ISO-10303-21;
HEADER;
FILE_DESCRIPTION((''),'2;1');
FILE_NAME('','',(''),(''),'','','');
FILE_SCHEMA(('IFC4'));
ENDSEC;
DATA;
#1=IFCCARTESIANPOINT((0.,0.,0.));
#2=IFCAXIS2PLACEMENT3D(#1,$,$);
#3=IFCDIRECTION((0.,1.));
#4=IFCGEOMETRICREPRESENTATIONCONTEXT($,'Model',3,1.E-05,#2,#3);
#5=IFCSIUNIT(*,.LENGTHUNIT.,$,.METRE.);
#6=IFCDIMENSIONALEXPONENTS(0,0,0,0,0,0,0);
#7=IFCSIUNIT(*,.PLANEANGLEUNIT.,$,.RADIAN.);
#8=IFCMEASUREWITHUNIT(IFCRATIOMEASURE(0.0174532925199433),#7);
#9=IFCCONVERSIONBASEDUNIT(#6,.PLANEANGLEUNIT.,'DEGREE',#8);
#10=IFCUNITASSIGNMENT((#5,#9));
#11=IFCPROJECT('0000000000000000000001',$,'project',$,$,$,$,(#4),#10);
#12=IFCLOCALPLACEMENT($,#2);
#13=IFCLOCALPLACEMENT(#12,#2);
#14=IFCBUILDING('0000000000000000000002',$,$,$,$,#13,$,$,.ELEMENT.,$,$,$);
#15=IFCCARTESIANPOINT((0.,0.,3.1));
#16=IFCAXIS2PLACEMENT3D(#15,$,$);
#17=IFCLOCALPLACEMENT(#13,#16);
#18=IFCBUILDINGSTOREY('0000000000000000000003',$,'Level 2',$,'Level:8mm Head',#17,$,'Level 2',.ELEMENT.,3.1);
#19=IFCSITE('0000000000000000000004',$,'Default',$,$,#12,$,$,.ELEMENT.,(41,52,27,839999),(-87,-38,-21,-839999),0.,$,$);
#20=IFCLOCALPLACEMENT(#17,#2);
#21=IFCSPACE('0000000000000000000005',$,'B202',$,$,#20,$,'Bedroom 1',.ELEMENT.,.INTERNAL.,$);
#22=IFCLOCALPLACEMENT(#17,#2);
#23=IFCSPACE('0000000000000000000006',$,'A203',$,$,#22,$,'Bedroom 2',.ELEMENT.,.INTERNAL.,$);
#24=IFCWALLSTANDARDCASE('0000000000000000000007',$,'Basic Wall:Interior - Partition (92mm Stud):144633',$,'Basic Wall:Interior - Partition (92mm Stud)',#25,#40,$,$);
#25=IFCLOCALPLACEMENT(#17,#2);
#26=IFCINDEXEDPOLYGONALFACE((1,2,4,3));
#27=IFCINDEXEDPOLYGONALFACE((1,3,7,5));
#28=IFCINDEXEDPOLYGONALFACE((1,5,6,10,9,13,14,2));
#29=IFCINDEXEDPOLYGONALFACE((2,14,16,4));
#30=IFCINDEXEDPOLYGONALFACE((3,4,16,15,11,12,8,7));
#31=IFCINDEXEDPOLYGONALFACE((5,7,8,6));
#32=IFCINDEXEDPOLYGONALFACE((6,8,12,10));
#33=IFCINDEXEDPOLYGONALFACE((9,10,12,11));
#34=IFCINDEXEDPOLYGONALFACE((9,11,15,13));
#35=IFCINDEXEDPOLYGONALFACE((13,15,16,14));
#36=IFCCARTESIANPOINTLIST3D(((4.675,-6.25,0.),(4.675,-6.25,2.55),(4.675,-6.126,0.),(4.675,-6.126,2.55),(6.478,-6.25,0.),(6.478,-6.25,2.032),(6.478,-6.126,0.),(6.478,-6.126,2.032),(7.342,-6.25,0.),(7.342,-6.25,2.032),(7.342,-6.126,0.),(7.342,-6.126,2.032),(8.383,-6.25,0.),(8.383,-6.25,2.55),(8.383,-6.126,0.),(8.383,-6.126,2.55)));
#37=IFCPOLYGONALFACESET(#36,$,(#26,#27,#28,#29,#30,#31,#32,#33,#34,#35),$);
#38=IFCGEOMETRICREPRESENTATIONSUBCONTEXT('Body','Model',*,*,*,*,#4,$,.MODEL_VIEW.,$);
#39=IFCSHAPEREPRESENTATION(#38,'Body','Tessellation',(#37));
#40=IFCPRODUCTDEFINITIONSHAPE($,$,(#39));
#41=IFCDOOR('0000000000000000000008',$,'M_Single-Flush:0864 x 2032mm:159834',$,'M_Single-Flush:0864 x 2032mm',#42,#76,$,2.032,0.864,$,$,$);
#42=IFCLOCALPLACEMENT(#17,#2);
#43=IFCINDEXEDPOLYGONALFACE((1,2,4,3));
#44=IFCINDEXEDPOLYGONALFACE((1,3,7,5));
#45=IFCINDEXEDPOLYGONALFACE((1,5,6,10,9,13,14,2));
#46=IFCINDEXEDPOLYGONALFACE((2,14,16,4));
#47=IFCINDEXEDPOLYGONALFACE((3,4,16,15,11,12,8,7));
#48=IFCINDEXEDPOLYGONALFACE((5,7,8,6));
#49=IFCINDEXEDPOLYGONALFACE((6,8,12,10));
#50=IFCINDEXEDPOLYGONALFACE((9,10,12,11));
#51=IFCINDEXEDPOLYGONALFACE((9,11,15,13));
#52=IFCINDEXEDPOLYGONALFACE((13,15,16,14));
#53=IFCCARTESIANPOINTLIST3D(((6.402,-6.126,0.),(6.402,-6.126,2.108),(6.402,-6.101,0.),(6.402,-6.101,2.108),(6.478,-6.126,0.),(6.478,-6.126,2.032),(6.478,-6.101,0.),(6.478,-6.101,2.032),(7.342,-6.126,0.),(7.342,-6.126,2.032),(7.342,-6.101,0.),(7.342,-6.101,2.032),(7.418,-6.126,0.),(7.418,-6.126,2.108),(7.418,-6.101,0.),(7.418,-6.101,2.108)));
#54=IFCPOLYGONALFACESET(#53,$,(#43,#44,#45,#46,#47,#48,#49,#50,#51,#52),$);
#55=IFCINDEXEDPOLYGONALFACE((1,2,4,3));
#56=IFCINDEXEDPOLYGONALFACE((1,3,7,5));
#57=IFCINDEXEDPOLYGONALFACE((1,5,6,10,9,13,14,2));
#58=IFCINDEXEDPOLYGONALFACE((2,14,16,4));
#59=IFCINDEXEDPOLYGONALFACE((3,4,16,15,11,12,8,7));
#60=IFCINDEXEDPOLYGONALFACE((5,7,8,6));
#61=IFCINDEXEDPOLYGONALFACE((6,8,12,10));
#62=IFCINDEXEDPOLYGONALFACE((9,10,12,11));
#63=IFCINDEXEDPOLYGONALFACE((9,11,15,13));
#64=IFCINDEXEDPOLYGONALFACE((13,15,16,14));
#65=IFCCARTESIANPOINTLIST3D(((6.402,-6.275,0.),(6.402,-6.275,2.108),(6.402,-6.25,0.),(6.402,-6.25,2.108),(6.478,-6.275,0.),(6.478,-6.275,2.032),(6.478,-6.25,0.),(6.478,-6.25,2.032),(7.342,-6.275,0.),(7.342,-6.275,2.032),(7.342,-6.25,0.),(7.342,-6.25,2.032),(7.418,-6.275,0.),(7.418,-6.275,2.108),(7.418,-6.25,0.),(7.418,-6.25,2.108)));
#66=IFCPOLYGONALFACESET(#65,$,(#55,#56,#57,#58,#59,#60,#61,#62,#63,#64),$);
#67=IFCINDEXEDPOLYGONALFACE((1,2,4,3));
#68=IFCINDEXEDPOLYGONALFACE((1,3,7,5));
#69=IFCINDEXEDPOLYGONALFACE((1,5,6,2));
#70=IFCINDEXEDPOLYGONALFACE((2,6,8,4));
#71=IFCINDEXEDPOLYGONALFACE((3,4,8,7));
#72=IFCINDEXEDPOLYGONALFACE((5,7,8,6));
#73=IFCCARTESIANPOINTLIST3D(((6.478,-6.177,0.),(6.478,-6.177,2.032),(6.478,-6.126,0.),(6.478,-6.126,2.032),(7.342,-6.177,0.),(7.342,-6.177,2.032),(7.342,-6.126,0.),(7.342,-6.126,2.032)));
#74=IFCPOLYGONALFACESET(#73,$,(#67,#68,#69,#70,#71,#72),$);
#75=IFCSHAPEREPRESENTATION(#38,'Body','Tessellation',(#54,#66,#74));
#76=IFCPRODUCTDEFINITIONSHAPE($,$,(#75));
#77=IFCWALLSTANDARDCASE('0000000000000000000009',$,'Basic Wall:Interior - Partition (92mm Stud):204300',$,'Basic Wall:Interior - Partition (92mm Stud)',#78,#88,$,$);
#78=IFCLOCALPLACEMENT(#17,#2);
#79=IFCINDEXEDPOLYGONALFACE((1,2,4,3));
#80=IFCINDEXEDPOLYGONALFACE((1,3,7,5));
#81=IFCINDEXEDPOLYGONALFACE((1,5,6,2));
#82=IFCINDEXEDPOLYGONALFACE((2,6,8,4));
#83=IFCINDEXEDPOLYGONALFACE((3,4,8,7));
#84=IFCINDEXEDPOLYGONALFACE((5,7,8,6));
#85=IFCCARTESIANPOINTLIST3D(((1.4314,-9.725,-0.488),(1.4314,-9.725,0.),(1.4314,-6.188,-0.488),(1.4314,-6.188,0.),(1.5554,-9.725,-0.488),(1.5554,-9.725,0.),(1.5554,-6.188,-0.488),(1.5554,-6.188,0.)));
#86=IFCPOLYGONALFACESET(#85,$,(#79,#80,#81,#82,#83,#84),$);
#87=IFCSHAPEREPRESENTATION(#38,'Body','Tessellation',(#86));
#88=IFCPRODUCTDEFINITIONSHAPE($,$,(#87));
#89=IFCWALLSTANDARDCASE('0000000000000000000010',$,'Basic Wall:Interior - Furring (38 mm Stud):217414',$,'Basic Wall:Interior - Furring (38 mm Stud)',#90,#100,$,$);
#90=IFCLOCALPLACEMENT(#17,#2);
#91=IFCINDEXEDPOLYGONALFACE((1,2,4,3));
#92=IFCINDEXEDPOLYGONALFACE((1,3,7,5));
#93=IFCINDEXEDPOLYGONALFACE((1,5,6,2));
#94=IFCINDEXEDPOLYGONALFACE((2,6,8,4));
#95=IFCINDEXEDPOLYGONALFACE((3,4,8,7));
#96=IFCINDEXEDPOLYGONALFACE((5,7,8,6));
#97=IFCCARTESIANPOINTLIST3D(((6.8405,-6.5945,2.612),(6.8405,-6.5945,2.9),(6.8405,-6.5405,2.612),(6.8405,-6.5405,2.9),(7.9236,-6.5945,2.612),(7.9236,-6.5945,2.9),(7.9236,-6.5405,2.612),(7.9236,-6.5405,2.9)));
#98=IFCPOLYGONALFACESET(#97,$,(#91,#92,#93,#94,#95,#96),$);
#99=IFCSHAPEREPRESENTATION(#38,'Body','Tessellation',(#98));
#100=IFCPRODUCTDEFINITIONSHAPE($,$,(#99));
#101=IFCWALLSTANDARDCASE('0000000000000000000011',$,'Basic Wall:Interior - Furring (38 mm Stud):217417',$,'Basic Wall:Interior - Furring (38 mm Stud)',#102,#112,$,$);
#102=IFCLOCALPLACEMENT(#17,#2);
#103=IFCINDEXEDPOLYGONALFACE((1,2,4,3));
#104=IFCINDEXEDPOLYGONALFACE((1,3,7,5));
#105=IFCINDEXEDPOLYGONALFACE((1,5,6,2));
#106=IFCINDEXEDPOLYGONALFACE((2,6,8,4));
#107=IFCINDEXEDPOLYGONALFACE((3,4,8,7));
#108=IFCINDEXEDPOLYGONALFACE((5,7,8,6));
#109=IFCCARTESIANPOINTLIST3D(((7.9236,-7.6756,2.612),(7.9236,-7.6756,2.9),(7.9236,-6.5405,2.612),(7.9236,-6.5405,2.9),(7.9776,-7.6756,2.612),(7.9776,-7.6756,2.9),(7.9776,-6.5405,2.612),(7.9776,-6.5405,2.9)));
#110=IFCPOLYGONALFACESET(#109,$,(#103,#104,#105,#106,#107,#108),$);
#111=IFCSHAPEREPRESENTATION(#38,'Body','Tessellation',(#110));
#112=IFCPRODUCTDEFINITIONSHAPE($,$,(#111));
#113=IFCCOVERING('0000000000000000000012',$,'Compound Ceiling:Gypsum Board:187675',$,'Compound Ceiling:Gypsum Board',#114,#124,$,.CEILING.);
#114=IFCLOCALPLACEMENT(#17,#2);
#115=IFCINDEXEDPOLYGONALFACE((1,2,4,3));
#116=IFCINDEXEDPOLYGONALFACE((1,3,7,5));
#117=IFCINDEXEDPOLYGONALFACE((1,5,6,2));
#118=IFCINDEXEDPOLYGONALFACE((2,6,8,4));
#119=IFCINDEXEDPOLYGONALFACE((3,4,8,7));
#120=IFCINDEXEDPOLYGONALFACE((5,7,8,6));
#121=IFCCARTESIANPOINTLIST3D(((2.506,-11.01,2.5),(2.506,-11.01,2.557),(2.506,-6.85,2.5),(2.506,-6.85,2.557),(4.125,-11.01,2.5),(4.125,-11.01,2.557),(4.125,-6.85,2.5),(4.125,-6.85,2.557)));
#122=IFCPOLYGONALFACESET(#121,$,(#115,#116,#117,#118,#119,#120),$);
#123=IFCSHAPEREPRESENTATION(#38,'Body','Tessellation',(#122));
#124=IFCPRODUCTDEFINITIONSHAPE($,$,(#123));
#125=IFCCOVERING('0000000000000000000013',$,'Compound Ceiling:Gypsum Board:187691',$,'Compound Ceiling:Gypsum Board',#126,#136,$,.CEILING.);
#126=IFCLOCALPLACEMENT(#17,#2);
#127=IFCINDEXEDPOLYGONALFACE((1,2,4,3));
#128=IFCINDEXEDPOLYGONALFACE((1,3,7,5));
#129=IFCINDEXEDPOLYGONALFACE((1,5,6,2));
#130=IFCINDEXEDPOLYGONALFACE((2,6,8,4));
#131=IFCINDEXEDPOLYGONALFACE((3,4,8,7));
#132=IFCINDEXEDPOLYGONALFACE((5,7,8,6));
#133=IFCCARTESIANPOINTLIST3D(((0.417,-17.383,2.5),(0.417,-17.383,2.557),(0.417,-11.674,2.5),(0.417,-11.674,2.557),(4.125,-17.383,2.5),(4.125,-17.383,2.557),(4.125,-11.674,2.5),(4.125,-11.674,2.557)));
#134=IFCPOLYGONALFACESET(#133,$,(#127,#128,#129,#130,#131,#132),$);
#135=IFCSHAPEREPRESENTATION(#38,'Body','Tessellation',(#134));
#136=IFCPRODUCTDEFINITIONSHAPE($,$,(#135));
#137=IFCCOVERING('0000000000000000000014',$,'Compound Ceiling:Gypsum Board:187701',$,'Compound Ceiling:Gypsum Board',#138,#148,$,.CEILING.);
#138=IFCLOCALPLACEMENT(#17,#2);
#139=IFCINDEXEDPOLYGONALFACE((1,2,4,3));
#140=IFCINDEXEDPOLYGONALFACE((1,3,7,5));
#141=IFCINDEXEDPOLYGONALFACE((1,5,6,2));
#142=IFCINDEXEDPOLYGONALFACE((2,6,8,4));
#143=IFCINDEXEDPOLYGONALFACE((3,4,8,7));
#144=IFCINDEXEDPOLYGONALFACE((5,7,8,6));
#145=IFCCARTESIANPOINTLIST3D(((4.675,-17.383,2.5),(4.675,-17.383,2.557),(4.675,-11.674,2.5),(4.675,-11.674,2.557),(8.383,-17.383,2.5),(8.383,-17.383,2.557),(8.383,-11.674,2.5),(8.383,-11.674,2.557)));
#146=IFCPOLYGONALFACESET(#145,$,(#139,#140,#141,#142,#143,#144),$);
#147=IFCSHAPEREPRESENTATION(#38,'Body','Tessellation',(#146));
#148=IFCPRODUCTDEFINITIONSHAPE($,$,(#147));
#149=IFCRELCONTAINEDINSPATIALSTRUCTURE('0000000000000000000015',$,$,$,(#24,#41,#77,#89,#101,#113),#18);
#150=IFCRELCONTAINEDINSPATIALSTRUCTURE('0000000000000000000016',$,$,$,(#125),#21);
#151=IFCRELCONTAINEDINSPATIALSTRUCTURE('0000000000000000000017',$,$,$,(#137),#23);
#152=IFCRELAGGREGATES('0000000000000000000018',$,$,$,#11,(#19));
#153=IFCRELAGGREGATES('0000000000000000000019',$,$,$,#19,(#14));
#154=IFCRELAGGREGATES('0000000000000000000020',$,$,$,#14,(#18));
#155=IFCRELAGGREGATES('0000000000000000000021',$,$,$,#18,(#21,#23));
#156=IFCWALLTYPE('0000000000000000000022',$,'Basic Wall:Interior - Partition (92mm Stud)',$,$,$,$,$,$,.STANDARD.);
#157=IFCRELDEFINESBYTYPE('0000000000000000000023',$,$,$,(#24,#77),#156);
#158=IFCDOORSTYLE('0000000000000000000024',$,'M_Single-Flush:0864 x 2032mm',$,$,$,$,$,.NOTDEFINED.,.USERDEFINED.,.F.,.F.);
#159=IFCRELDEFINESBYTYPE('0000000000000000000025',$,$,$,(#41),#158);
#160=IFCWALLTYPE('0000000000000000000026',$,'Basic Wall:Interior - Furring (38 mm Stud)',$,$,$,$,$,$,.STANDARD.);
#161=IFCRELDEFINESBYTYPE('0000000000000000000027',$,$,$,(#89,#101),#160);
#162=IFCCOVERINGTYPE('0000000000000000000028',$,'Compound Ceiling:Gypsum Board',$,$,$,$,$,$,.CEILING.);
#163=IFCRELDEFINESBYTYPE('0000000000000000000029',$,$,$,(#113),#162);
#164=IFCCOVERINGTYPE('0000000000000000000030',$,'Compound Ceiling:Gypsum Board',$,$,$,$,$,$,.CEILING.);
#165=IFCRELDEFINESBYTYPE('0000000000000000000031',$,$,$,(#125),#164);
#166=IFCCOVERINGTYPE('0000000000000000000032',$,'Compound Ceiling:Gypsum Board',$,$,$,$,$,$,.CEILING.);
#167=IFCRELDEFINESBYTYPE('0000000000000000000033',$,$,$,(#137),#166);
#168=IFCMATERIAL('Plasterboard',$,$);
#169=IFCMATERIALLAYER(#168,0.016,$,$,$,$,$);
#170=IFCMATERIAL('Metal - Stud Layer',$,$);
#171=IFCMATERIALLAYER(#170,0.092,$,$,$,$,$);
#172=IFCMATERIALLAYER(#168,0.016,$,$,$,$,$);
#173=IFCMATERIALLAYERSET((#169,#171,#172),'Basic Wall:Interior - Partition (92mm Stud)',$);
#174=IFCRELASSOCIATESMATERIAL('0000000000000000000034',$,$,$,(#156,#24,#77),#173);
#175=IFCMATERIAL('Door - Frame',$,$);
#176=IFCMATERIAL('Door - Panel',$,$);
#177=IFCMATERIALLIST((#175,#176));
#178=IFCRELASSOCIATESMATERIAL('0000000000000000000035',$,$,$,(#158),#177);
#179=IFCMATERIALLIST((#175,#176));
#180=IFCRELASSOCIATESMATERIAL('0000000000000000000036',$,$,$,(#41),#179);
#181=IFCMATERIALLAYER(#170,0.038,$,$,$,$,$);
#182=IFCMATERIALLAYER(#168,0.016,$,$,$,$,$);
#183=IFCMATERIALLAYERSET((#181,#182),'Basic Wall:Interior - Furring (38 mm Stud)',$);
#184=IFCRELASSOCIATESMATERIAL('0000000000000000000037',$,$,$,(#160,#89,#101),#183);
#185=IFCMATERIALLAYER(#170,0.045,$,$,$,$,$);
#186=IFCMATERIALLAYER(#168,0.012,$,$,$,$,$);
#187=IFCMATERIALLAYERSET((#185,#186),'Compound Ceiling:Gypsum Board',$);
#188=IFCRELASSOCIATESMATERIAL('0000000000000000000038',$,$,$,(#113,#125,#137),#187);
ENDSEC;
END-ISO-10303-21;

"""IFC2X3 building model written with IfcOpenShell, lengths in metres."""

from ifc_helpers import new_model, entity, si_unit, converted_unit, direction, frame, frame_2d, origin, place, context, subcontext, project, spatial, polyline, rectangle, outline, extrude, source, transform, mapped, material, material_list, layer, layer_set, layer_usage, type_object, type_shapes, element, fill, save


model = new_model("IFC2X3")

# Units and contexts
model_context = context("Model", 3, precision=1e-05, world=origin(), true_north=direction((0.0, 1.0)))
body_context = subcontext(model_context, "Body", "Model", "MODEL_VIEW")
ifc_project = project(units=[si_unit("LENGTHUNIT", "METRE"), converted_unit("PLANEANGLEUNIT", "DEGREE", entity("IfcRatioMeasure", 0.0174532925199433), si_unit("PLANEANGLEUNIT", "RADIAN"), dimensions=[0, 0, 0, 0, 0, 0, 0])], contexts=[model_context])

# Site, building, storey
site_placement = place(None, origin())
site = spatial("IfcSite", under=ifc_project, at=site_placement, Name="Default", CompositionType="ELEMENT", RefLatitude=(41, 52, 27, 839999), RefLongitude=(-87, -38, -21, -839999), RefElevation=0.0)
building_placement = place(site_placement, origin())
building = spatial("IfcBuilding", under=site, at=building_placement, CompositionType="ELEMENT")
storey_placement = place(building_placement, frame((0.0, 0.0, 3.1)))
storey = spatial("IfcBuildingStorey", under=building, at=storey_placement, Name="Level 2", ObjectType="Level:8mm Head", LongName="Level 2", CompositionType="ELEMENT", Elevation=3.1)

# Shared definitions
ifc_material_1 = material(Name="Metal - Stud Layer")
ifc_material_2 = material(Name="Plasterboard")

# Wall, opening, door
ifc_layer_1 = layer(ifc_material_2, 0.016)
ifc_layer_2 = layer(ifc_material_1, 0.092)
ifc_layer_3 = layer(ifc_material_2, 0.016)
ifc_layer_set_1 = layer_set([ifc_layer_1, ifc_layer_2, ifc_layer_3], Name="Basic Wall:Interior - Partition (92mm Stud)")
wall_type_1 = type_object("IfcWallType", Name="Basic Wall:Interior - Partition (92mm Stud)", PredefinedType="STANDARD", material=ifc_layer_set_1)
ifc_material_3 = material(Name="Door - Frame")
ifc_material_4 = material(Name="Door - Panel")
ifc_layer_usage_1 = layer_usage(ifc_layer_set_1, "AXIS2", "NEGATIVE", 0.062)
wall_1_placement = place(storey_placement, frame((4.675, -6.188, 0.0)))
wall_1 = element("IfcWallStandardCase", 1, at=wall_1_placement, inside=storey, type_object=wall_type_1, material=ifc_layer_usage_1, Name="Basic Wall:Interior - Partition (92mm Stud):144633", ObjectType="Basic Wall:Interior - Partition (92mm Stud)", context=body_context, shape_type="SweptSolid", body=[
    extrude(rectangle(XDim=3.708, YDim=0.124, at=frame_2d((1.854, 0.0), x_axis=(-1.0, 0.0))), origin(), (0.0, 0.0, 1.0), 2.55),
])
opening_1_placement = place(wall_1_placement, frame((1.803, -0.062, 0.0)))
opening_1 = element("IfcOpeningElement", 2, at=opening_1_placement, cuts=wall_1, ObjectType="Opening", context=body_context, shape_type="SweptSolid", body=[
    extrude(rectangle(XDim=0.864, YDim=2.032, at=frame_2d((1.016, 0.432), x_axis=(0.0, -1.0))), frame((0.0, 0.0, 0.0), z_axis=(0.0, 1.0, 0.0), x_axis=(0.0, 0.0, 1.0)), (0.0, 0.0, 1.0), 0.124),
])
ifc_material_list_1 = material_list([ifc_material_3, ifc_material_4])
ifc_material_list_2 = material_list([ifc_material_3, ifc_material_4])
door_style_1 = type_object("IfcDoorStyle", Name="M_Single-Flush:0864 x 2032mm", ConstructionType="USERDEFINED", OperationType="NOTDEFINED", ParameterTakesPrecedence=False, Sizeable=False, material=ifc_material_list_2)
shared_shape_1 = source(origin(), body_context, "Body", "SweptSolid", [
    extrude(outline(polyline([(-0.508, -1.073), (0.508, -1.073), (0.508, 1.035), (0.432, 1.035), (0.432, -0.997), (-0.432, -0.997), (-0.432, 1.035), (-0.508, 1.035), (-0.508, -1.073)])), frame((0.432, 0.149, 1.035), z_axis=(0.0, -1.0, 0.0), x_axis=(-1.0, 0.0, 0.0)), (0.0, 0.0, 1.0), 0.025),
    extrude(outline(polyline([(-1.073, -0.508), (1.035, -0.508), (1.035, -0.432), (-0.997, -0.432), (-0.997, 0.432), (1.035, 0.432), (1.035, 0.508), (-1.073, 0.508), (-1.073, -0.508)])), frame((0.432, 0.0, 1.035), z_axis=(0.0, -1.0, 0.0), x_axis=(0.0, 0.0, -1.0)), (0.0, 0.0, 1.0), 0.025),
    extrude(rectangle(XDim=0.864, YDim=0.051, at=frame_2d((0.0, 0.0), x_axis=(1.0, 0.0))), frame((0.432, 0.0985, 0.0)), (0.0, 0.0, 1.0), 2.032),
])
type_shapes(door_style_1, [shared_shape_1])
door_1_placement = place(opening_1_placement, origin())
door_1 = element("IfcDoor", 3, at=door_1_placement, inside=storey, type_object=door_style_1, material=ifc_material_list_1, Name="M_Single-Flush:0864 x 2032mm:159834", ObjectType="M_Single-Flush:0864 x 2032mm", OverallHeight=2.032, OverallWidth=0.864, context=body_context, shape_type="MappedRepresentation", body=[
    mapped(shared_shape_1, transform((0.0, 0.0, 0.0), scale=1.0)),
])
fill(opening_1, door_1)

# Walls
ifc_layer_usage_2 = layer_usage(ifc_layer_set_1, "AXIS2", "NEGATIVE", 0.062)
wall_2_placement = place(storey_placement, frame((1.4934, -6.188, -0.488), z_axis=(0.0, 0.0, 1.0), x_axis=(0.0, -1.0, 0.0)))
element("IfcWallStandardCase", 4, at=wall_2_placement, inside=storey, type_object=wall_type_1, material=ifc_layer_usage_2, Name="Basic Wall:Interior - Partition (92mm Stud):204300", ObjectType="Basic Wall:Interior - Partition (92mm Stud)", context=body_context, shape_type="SweptSolid", body=[
    extrude(rectangle(XDim=3.537, YDim=0.124, at=frame_2d((1.7685, 0.0), x_axis=(-1.0, 0.0))), origin(), (0.0, 0.0, 1.0), 0.488),
])
ifc_layer_4 = layer(ifc_material_1, 0.038)
ifc_layer_5 = layer(ifc_material_2, 0.016)
ifc_layer_set_2 = layer_set([ifc_layer_4, ifc_layer_5], Name="Basic Wall:Interior - Furring (38 mm Stud)")
ifc_layer_usage_3 = layer_usage(ifc_layer_set_2, "AXIS2", "NEGATIVE", 0.027)
wall_type_2 = type_object("IfcWallType", Name="Basic Wall:Interior - Furring (38 mm Stud)", PredefinedType="STANDARD", material=ifc_layer_set_2)
wall_3_placement = place(storey_placement, frame((6.8405, -6.5675, 2.612)))
element("IfcWallStandardCase", 5, at=wall_3_placement, inside=storey, type_object=wall_type_2, material=ifc_layer_usage_3, Name="Basic Wall:Interior - Furring (38 mm Stud):217414", ObjectType="Basic Wall:Interior - Furring (38 mm Stud)", context=body_context, shape_type="SweptSolid", body=[
    extrude(rectangle(XDim=1.0831, YDim=0.054, at=frame_2d((0.5415, 0.0), x_axis=(-1.0, 0.0))), origin(), (0.0, 0.0, 1.0), 0.288),
])
ifc_layer_usage_4 = layer_usage(ifc_layer_set_2, "AXIS2", "NEGATIVE", 0.027)
wall_4_placement = place(storey_placement, frame((7.9506, -6.5405, 2.612), z_axis=(0.0, 0.0, 1.0), x_axis=(0.0, -1.0, 0.0)))
element("IfcWallStandardCase", 6, at=wall_4_placement, inside=storey, type_object=wall_type_2, material=ifc_layer_usage_4, Name="Basic Wall:Interior - Furring (38 mm Stud):217417", ObjectType="Basic Wall:Interior - Furring (38 mm Stud)", context=body_context, shape_type="SweptSolid", body=[
    extrude(rectangle(XDim=1.1351, YDim=0.054, at=frame_2d((0.5675, 0.0), x_axis=(-1.0, 0.0))), origin(), (0.0, 0.0, 1.0), 0.288),
])

# Covering
ifc_layer_6 = layer(ifc_material_1, 0.045)
ifc_layer_7 = layer(ifc_material_2, 0.012)
ifc_layer_set_3 = layer_set([ifc_layer_6, ifc_layer_7], Name="Compound Ceiling:Gypsum Board")
ifc_layer_usage_5 = layer_usage(ifc_layer_set_3, "AXIS3", "POSITIVE", 0.0)
covering_type_1 = type_object("IfcCoveringType", Name="Compound Ceiling:Gypsum Board", PredefinedType="CEILING")
covering_1_placement = place(storey_placement, origin())
element("IfcCovering", 7, at=covering_1_placement, inside=storey, type_object=covering_type_1, material=ifc_layer_usage_5, Name="Compound Ceiling:Gypsum Board:187675", ObjectType="Compound Ceiling:Gypsum Board", PredefinedType="CEILING", context=body_context, shape_type="SweptSolid", body=[
    extrude(rectangle(XDim=1.619, YDim=4.16, at=frame_2d((0.0, 0.0), x_axis=(1.0, 0.0))), frame((3.3155, -8.93, 2.5), z_axis=(0.0, 0.0, 1.0), x_axis=(-1.0, 0.0, 0.0)), (0.0, 0.0, 1.0), 0.057),
])

# Shared definitions
space_1_placement = place(storey_placement, origin())
space_1 = spatial("IfcSpace", under=storey, at=space_1_placement, Name="B202", LongName="Bedroom 1", CompositionType="ELEMENT", InteriorOrExteriorSpace="INTERNAL")

# Covering
ifc_layer_usage_6 = layer_usage(ifc_layer_set_3, "AXIS3", "POSITIVE", 0.0)
covering_type_2 = type_object("IfcCoveringType", Name="Compound Ceiling:Gypsum Board", PredefinedType="CEILING")
covering_2_placement = place(space_1_placement, origin())
element("IfcCovering", 8, at=covering_2_placement, inside=space_1, type_object=covering_type_2, material=ifc_layer_usage_6, Name="Compound Ceiling:Gypsum Board:187691", ObjectType="Compound Ceiling:Gypsum Board", PredefinedType="CEILING", context=body_context, shape_type="SweptSolid", body=[
    extrude(rectangle(XDim=5.709, YDim=3.708, at=frame_2d((0.0, 0.0), x_axis=(1.0, 0.0))), frame((2.271, -14.5285, 2.5), z_axis=(0.0, 0.0, 1.0), x_axis=(0.0, -1.0, 0.0)), (0.0, 0.0, 1.0), 0.057),
])

# Shared definitions
space_2_placement = place(storey_placement, origin())
space_2 = spatial("IfcSpace", under=storey, at=space_2_placement, Name="A203", LongName="Bedroom 2", CompositionType="ELEMENT", InteriorOrExteriorSpace="INTERNAL")

# Covering
ifc_layer_usage_7 = layer_usage(ifc_layer_set_3, "AXIS3", "POSITIVE", 0.0)
covering_type_3 = type_object("IfcCoveringType", Name="Compound Ceiling:Gypsum Board", PredefinedType="CEILING")
covering_3_placement = place(space_2_placement, origin())
element("IfcCovering", 9, at=covering_3_placement, inside=space_2, type_object=covering_type_3, material=ifc_layer_usage_7, Name="Compound Ceiling:Gypsum Board:187701", ObjectType="Compound Ceiling:Gypsum Board", PredefinedType="CEILING", context=body_context, shape_type="SweptSolid", body=[
    extrude(rectangle(XDim=3.708, YDim=5.709, at=frame_2d((0.0, 0.0), x_axis=(1.0, 0.0))), frame((6.529, -14.5285, 2.5)), (0.0, 0.0, 1.0), 0.057),
])

save(model, "model.ifc")
